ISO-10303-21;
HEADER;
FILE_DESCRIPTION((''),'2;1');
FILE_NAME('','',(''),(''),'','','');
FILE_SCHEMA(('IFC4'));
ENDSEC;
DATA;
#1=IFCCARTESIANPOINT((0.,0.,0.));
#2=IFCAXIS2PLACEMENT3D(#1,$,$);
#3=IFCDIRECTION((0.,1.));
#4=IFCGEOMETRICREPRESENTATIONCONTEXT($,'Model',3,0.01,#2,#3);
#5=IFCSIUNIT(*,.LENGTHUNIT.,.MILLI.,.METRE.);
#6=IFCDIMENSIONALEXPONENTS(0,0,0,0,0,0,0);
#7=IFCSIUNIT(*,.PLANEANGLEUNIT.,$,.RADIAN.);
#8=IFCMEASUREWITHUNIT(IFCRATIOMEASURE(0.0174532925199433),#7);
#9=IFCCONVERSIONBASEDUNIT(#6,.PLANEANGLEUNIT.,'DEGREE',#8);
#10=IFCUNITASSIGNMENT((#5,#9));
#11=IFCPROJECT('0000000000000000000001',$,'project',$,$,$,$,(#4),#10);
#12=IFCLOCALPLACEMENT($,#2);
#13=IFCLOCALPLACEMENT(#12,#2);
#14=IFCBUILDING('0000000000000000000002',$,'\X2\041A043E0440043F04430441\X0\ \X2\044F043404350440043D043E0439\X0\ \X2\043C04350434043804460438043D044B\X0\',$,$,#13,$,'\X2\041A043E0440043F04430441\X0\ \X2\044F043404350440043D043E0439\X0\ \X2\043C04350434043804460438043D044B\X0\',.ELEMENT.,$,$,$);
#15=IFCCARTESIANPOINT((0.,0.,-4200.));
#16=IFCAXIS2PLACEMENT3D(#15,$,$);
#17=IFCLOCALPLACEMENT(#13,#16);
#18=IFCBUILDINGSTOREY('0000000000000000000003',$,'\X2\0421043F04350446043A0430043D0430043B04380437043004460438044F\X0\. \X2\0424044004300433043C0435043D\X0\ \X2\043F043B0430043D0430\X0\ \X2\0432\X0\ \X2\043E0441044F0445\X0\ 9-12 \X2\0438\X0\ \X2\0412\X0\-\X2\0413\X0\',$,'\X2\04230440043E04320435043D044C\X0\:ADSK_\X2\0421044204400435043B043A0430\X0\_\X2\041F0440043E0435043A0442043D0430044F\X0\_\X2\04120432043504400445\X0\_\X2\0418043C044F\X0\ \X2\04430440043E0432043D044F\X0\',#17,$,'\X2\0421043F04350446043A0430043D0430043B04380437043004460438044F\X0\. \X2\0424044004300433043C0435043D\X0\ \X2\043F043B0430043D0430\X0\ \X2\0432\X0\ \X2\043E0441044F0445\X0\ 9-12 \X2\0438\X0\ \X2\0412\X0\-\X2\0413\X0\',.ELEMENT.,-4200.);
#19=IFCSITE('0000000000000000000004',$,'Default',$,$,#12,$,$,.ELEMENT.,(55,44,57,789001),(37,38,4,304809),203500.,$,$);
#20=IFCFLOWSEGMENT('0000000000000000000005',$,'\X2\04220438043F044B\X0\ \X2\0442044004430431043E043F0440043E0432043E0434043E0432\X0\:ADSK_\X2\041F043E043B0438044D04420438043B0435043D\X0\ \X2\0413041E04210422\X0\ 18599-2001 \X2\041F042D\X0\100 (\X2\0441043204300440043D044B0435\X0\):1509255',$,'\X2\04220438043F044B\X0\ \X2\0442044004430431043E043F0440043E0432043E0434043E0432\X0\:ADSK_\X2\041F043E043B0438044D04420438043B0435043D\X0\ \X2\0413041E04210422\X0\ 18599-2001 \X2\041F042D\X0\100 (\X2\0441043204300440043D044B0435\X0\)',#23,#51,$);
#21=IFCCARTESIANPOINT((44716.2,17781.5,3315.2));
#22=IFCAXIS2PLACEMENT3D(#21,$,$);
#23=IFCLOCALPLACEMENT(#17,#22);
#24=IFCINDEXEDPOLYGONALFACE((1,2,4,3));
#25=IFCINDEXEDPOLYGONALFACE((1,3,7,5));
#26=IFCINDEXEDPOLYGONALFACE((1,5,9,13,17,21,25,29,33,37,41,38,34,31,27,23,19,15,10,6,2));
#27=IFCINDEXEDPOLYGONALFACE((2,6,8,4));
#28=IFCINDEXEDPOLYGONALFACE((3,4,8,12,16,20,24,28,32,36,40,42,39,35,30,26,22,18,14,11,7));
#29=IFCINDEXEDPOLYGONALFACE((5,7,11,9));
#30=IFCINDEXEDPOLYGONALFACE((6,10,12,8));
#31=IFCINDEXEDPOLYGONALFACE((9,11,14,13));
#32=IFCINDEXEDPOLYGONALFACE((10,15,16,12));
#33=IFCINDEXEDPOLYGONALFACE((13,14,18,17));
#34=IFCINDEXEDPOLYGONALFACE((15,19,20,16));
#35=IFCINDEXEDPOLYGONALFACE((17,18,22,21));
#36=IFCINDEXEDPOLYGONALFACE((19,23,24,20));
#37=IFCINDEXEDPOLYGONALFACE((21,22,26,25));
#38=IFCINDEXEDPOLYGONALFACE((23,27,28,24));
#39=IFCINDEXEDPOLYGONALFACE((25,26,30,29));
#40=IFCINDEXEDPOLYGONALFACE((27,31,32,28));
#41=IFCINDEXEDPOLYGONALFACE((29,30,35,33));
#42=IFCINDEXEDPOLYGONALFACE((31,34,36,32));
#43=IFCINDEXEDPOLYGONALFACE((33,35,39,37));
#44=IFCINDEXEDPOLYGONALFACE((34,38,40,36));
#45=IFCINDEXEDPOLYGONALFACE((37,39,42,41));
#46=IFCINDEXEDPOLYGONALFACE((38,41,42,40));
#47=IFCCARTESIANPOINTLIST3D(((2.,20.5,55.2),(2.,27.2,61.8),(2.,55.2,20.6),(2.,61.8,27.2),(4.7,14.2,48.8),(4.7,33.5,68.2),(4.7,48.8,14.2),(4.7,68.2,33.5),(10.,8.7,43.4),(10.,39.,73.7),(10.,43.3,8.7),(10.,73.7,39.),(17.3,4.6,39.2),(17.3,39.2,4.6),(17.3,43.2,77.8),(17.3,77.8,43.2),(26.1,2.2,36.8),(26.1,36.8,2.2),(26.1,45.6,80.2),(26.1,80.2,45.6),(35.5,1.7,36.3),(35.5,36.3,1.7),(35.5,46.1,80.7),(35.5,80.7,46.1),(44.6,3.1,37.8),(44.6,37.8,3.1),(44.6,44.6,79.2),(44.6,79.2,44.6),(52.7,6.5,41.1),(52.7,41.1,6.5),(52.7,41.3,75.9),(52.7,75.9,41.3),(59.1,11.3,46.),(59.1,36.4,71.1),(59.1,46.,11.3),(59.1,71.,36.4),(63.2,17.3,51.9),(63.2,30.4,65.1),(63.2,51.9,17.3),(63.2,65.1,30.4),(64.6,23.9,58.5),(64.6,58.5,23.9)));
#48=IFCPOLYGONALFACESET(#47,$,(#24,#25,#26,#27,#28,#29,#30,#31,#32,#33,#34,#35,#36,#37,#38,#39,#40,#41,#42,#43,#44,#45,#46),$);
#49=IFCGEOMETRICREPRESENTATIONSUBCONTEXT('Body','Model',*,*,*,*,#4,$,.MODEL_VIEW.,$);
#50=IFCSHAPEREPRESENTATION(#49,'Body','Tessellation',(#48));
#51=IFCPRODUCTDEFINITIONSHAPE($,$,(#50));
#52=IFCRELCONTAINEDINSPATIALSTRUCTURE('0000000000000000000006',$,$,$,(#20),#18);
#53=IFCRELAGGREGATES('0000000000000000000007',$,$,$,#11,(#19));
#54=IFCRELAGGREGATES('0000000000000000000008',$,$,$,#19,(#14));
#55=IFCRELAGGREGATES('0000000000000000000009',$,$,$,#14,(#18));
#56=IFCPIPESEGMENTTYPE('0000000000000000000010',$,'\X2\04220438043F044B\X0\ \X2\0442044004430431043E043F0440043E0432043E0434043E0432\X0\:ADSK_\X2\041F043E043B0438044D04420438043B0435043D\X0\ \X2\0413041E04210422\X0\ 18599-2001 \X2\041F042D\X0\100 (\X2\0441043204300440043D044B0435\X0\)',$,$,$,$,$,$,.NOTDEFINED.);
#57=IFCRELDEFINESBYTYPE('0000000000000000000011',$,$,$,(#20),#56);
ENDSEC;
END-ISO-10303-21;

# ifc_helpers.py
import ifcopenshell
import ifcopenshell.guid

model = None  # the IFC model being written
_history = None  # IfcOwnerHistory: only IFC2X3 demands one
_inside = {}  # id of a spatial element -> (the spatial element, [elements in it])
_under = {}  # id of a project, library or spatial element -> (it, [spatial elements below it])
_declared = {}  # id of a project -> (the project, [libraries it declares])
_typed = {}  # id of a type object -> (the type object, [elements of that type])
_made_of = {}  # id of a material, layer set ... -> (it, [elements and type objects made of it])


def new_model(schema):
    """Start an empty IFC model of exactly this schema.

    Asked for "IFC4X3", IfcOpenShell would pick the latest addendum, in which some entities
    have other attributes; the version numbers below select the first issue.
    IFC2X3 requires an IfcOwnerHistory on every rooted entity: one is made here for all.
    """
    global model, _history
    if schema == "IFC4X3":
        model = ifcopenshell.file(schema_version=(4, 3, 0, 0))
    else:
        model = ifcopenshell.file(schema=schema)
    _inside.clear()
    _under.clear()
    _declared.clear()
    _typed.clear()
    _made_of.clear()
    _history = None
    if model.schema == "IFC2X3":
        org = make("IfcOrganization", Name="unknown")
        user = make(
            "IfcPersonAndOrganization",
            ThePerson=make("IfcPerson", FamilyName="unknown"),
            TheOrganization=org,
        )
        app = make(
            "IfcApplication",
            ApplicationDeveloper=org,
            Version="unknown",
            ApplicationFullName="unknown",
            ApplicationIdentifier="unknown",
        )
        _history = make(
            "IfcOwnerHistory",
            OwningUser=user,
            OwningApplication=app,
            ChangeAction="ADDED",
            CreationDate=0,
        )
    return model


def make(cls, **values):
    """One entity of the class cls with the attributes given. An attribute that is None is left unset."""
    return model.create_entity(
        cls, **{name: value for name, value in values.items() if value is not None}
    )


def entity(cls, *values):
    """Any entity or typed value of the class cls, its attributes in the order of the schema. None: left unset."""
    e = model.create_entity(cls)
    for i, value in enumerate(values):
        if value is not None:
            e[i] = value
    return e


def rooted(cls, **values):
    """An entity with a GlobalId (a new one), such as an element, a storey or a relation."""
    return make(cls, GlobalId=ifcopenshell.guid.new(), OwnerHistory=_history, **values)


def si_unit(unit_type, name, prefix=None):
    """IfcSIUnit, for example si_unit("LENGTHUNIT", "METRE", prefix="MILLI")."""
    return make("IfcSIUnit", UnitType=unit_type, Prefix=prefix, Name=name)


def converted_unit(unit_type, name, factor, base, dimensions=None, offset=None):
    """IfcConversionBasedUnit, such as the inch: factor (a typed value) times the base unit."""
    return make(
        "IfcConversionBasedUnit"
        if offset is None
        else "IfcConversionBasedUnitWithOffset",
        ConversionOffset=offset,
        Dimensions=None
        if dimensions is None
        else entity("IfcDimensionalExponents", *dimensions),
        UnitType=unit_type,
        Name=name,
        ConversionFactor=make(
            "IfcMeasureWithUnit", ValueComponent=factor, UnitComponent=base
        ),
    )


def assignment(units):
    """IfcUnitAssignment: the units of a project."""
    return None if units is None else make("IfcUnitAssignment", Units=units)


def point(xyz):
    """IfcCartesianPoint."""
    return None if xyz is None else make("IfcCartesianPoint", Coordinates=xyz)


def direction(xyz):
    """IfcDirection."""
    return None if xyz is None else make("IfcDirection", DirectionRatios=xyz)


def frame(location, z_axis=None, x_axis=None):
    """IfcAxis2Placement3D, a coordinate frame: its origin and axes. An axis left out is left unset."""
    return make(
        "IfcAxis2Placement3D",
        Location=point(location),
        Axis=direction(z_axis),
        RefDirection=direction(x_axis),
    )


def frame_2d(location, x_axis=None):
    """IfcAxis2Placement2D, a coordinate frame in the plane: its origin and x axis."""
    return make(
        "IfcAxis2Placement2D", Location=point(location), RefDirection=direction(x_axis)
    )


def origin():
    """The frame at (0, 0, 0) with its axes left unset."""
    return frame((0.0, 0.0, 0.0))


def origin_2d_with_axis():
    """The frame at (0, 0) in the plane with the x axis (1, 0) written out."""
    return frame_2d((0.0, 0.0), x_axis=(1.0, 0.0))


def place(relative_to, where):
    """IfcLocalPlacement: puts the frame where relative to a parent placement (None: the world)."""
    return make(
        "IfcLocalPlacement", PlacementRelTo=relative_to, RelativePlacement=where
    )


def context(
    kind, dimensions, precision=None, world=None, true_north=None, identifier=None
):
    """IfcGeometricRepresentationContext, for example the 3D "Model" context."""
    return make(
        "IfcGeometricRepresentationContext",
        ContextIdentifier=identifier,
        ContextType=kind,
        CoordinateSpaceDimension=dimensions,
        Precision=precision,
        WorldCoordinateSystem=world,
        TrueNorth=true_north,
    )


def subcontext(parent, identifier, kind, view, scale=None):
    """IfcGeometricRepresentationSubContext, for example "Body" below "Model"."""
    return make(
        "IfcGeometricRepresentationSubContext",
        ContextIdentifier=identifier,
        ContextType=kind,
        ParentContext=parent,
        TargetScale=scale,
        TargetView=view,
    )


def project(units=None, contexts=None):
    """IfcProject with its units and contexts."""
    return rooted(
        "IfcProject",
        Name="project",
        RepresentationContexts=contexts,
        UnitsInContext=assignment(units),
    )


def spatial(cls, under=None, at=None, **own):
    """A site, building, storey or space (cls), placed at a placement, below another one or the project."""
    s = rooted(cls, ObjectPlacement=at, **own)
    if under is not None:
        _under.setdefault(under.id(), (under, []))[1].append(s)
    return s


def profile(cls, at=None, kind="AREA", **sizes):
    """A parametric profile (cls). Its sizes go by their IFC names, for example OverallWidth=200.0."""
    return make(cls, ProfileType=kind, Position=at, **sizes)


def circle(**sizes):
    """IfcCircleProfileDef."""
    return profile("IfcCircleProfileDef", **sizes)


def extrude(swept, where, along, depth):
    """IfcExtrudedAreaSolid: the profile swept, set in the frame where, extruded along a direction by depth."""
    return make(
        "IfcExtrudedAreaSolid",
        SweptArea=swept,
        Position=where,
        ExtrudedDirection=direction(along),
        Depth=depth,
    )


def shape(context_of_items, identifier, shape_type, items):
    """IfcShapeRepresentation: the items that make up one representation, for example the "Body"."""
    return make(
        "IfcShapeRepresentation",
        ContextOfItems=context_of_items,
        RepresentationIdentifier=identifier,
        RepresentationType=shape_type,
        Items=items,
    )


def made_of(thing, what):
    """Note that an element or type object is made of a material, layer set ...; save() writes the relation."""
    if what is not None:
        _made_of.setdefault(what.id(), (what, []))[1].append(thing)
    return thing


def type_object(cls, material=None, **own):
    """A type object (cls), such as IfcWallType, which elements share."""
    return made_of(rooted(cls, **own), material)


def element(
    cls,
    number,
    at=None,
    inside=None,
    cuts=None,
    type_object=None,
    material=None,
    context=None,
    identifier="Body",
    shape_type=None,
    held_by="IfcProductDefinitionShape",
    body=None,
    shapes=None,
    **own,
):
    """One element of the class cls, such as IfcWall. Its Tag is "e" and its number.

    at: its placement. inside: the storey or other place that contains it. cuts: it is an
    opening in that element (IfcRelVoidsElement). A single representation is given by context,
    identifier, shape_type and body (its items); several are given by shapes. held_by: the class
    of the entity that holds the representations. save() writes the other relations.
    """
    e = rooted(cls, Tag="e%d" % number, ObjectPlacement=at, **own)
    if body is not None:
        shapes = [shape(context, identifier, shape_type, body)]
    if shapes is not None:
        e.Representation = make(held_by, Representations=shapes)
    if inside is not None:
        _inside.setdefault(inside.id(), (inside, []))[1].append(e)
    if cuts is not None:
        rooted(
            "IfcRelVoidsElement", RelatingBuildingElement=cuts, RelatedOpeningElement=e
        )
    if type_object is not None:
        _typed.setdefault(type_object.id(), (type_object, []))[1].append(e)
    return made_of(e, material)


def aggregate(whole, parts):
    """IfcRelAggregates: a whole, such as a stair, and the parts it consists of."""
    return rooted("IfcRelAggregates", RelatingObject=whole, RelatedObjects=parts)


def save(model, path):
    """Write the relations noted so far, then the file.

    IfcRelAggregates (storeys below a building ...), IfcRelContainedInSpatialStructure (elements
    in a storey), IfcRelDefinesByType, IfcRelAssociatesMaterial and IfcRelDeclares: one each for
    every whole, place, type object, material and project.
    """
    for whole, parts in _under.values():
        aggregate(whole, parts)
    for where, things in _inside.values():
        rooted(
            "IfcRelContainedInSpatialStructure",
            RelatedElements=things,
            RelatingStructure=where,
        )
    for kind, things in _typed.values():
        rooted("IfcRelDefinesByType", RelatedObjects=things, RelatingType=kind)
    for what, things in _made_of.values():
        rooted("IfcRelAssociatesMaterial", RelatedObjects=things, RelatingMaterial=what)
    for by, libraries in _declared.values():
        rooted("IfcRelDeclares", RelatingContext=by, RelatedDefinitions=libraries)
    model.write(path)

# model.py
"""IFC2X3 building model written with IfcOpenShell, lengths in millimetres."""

from ifc_helpers import new_model, entity, si_unit, converted_unit, direction, frame, origin, origin_2d_with_axis, place, context, subcontext, project, spatial, circle, extrude, type_object, element, save


model = new_model("IFC2X3")

# Units and contexts
model_context = context("Model", 3, precision=0.01, world=origin(), true_north=direction((0.0, 1.0)))
body_context = subcontext(model_context, "Body", "Model", "MODEL_VIEW")
ifc_project = project(units=[si_unit("LENGTHUNIT", "METRE", prefix="MILLI"), converted_unit("PLANEANGLEUNIT", "DEGREE", entity("IfcRatioMeasure", 0.0174532925199433), si_unit("PLANEANGLEUNIT", "RADIAN"), dimensions=[0, 0, 0, 0, 0, 0, 0])], contexts=[model_context])

# Site, building, storey
site_placement = place(None, origin())
site = spatial("IfcSite", under=ifc_project, at=site_placement, Name="Default", CompositionType="ELEMENT", RefLatitude=(55, 44, 57, 789001), RefLongitude=(37, 38, 4, 304809), RefElevation=203500.0)
building_placement = place(site_placement, origin())
building = spatial("IfcBuilding", under=site, at=building_placement, Name="Корпус ядерной медицины", LongName="Корпус ядерной медицины", CompositionType="ELEMENT")
storey_placement = place(building_placement, frame((0.0, 0.0, -4200.0)))
storey = spatial("IfcBuildingStorey", under=building, at=storey_placement, Name="Спецканализация. Фрагмен плана в осях 9-12 и В-Г", ObjectType="Уровень:ADSK_Стрелка_Проектная_Вверх_Имя уровня", LongName="Спецканализация. Фрагмен плана в осях 9-12 и В-Г", CompositionType="ELEMENT", Elevation=-4200.0)

# Flow segment
pipe_segment_type = type_object("IfcPipeSegmentType", Name="Типы трубопроводов:ADSK_Полиэтилен ГОСТ 18599-2001 ПЭ100 (сварные)", PredefinedType="NOTDEFINED")
flow_segment_1_placement = place(storey_placement, frame((44716.2, 17781.5, 3315.2)))
element("IfcFlowSegment", 1, at=flow_segment_1_placement, inside=storey, type_object=pipe_segment_type, Name="Типы трубопроводов:ADSK_Полиэтилен ГОСТ 18599-2001 ПЭ100 (сварные):1509255", ObjectType="Типы трубопроводов:ADSK_Полиэтилен ГОСТ 18599-2001 ПЭ100 (сварные)", context=body_context, shape_type="SweptSolid", body=[
    extrude(circle(Radius=31.5, at=origin_2d_with_axis()), frame((33.1, 58.5, 23.9), z_axis=(0.0, -0.707107, 0.707107), x_axis=(1.0, 0.0, 0.0)), (0.0, 0.0, 1.0), 49.0),
])

save(model, "model.ifc")
